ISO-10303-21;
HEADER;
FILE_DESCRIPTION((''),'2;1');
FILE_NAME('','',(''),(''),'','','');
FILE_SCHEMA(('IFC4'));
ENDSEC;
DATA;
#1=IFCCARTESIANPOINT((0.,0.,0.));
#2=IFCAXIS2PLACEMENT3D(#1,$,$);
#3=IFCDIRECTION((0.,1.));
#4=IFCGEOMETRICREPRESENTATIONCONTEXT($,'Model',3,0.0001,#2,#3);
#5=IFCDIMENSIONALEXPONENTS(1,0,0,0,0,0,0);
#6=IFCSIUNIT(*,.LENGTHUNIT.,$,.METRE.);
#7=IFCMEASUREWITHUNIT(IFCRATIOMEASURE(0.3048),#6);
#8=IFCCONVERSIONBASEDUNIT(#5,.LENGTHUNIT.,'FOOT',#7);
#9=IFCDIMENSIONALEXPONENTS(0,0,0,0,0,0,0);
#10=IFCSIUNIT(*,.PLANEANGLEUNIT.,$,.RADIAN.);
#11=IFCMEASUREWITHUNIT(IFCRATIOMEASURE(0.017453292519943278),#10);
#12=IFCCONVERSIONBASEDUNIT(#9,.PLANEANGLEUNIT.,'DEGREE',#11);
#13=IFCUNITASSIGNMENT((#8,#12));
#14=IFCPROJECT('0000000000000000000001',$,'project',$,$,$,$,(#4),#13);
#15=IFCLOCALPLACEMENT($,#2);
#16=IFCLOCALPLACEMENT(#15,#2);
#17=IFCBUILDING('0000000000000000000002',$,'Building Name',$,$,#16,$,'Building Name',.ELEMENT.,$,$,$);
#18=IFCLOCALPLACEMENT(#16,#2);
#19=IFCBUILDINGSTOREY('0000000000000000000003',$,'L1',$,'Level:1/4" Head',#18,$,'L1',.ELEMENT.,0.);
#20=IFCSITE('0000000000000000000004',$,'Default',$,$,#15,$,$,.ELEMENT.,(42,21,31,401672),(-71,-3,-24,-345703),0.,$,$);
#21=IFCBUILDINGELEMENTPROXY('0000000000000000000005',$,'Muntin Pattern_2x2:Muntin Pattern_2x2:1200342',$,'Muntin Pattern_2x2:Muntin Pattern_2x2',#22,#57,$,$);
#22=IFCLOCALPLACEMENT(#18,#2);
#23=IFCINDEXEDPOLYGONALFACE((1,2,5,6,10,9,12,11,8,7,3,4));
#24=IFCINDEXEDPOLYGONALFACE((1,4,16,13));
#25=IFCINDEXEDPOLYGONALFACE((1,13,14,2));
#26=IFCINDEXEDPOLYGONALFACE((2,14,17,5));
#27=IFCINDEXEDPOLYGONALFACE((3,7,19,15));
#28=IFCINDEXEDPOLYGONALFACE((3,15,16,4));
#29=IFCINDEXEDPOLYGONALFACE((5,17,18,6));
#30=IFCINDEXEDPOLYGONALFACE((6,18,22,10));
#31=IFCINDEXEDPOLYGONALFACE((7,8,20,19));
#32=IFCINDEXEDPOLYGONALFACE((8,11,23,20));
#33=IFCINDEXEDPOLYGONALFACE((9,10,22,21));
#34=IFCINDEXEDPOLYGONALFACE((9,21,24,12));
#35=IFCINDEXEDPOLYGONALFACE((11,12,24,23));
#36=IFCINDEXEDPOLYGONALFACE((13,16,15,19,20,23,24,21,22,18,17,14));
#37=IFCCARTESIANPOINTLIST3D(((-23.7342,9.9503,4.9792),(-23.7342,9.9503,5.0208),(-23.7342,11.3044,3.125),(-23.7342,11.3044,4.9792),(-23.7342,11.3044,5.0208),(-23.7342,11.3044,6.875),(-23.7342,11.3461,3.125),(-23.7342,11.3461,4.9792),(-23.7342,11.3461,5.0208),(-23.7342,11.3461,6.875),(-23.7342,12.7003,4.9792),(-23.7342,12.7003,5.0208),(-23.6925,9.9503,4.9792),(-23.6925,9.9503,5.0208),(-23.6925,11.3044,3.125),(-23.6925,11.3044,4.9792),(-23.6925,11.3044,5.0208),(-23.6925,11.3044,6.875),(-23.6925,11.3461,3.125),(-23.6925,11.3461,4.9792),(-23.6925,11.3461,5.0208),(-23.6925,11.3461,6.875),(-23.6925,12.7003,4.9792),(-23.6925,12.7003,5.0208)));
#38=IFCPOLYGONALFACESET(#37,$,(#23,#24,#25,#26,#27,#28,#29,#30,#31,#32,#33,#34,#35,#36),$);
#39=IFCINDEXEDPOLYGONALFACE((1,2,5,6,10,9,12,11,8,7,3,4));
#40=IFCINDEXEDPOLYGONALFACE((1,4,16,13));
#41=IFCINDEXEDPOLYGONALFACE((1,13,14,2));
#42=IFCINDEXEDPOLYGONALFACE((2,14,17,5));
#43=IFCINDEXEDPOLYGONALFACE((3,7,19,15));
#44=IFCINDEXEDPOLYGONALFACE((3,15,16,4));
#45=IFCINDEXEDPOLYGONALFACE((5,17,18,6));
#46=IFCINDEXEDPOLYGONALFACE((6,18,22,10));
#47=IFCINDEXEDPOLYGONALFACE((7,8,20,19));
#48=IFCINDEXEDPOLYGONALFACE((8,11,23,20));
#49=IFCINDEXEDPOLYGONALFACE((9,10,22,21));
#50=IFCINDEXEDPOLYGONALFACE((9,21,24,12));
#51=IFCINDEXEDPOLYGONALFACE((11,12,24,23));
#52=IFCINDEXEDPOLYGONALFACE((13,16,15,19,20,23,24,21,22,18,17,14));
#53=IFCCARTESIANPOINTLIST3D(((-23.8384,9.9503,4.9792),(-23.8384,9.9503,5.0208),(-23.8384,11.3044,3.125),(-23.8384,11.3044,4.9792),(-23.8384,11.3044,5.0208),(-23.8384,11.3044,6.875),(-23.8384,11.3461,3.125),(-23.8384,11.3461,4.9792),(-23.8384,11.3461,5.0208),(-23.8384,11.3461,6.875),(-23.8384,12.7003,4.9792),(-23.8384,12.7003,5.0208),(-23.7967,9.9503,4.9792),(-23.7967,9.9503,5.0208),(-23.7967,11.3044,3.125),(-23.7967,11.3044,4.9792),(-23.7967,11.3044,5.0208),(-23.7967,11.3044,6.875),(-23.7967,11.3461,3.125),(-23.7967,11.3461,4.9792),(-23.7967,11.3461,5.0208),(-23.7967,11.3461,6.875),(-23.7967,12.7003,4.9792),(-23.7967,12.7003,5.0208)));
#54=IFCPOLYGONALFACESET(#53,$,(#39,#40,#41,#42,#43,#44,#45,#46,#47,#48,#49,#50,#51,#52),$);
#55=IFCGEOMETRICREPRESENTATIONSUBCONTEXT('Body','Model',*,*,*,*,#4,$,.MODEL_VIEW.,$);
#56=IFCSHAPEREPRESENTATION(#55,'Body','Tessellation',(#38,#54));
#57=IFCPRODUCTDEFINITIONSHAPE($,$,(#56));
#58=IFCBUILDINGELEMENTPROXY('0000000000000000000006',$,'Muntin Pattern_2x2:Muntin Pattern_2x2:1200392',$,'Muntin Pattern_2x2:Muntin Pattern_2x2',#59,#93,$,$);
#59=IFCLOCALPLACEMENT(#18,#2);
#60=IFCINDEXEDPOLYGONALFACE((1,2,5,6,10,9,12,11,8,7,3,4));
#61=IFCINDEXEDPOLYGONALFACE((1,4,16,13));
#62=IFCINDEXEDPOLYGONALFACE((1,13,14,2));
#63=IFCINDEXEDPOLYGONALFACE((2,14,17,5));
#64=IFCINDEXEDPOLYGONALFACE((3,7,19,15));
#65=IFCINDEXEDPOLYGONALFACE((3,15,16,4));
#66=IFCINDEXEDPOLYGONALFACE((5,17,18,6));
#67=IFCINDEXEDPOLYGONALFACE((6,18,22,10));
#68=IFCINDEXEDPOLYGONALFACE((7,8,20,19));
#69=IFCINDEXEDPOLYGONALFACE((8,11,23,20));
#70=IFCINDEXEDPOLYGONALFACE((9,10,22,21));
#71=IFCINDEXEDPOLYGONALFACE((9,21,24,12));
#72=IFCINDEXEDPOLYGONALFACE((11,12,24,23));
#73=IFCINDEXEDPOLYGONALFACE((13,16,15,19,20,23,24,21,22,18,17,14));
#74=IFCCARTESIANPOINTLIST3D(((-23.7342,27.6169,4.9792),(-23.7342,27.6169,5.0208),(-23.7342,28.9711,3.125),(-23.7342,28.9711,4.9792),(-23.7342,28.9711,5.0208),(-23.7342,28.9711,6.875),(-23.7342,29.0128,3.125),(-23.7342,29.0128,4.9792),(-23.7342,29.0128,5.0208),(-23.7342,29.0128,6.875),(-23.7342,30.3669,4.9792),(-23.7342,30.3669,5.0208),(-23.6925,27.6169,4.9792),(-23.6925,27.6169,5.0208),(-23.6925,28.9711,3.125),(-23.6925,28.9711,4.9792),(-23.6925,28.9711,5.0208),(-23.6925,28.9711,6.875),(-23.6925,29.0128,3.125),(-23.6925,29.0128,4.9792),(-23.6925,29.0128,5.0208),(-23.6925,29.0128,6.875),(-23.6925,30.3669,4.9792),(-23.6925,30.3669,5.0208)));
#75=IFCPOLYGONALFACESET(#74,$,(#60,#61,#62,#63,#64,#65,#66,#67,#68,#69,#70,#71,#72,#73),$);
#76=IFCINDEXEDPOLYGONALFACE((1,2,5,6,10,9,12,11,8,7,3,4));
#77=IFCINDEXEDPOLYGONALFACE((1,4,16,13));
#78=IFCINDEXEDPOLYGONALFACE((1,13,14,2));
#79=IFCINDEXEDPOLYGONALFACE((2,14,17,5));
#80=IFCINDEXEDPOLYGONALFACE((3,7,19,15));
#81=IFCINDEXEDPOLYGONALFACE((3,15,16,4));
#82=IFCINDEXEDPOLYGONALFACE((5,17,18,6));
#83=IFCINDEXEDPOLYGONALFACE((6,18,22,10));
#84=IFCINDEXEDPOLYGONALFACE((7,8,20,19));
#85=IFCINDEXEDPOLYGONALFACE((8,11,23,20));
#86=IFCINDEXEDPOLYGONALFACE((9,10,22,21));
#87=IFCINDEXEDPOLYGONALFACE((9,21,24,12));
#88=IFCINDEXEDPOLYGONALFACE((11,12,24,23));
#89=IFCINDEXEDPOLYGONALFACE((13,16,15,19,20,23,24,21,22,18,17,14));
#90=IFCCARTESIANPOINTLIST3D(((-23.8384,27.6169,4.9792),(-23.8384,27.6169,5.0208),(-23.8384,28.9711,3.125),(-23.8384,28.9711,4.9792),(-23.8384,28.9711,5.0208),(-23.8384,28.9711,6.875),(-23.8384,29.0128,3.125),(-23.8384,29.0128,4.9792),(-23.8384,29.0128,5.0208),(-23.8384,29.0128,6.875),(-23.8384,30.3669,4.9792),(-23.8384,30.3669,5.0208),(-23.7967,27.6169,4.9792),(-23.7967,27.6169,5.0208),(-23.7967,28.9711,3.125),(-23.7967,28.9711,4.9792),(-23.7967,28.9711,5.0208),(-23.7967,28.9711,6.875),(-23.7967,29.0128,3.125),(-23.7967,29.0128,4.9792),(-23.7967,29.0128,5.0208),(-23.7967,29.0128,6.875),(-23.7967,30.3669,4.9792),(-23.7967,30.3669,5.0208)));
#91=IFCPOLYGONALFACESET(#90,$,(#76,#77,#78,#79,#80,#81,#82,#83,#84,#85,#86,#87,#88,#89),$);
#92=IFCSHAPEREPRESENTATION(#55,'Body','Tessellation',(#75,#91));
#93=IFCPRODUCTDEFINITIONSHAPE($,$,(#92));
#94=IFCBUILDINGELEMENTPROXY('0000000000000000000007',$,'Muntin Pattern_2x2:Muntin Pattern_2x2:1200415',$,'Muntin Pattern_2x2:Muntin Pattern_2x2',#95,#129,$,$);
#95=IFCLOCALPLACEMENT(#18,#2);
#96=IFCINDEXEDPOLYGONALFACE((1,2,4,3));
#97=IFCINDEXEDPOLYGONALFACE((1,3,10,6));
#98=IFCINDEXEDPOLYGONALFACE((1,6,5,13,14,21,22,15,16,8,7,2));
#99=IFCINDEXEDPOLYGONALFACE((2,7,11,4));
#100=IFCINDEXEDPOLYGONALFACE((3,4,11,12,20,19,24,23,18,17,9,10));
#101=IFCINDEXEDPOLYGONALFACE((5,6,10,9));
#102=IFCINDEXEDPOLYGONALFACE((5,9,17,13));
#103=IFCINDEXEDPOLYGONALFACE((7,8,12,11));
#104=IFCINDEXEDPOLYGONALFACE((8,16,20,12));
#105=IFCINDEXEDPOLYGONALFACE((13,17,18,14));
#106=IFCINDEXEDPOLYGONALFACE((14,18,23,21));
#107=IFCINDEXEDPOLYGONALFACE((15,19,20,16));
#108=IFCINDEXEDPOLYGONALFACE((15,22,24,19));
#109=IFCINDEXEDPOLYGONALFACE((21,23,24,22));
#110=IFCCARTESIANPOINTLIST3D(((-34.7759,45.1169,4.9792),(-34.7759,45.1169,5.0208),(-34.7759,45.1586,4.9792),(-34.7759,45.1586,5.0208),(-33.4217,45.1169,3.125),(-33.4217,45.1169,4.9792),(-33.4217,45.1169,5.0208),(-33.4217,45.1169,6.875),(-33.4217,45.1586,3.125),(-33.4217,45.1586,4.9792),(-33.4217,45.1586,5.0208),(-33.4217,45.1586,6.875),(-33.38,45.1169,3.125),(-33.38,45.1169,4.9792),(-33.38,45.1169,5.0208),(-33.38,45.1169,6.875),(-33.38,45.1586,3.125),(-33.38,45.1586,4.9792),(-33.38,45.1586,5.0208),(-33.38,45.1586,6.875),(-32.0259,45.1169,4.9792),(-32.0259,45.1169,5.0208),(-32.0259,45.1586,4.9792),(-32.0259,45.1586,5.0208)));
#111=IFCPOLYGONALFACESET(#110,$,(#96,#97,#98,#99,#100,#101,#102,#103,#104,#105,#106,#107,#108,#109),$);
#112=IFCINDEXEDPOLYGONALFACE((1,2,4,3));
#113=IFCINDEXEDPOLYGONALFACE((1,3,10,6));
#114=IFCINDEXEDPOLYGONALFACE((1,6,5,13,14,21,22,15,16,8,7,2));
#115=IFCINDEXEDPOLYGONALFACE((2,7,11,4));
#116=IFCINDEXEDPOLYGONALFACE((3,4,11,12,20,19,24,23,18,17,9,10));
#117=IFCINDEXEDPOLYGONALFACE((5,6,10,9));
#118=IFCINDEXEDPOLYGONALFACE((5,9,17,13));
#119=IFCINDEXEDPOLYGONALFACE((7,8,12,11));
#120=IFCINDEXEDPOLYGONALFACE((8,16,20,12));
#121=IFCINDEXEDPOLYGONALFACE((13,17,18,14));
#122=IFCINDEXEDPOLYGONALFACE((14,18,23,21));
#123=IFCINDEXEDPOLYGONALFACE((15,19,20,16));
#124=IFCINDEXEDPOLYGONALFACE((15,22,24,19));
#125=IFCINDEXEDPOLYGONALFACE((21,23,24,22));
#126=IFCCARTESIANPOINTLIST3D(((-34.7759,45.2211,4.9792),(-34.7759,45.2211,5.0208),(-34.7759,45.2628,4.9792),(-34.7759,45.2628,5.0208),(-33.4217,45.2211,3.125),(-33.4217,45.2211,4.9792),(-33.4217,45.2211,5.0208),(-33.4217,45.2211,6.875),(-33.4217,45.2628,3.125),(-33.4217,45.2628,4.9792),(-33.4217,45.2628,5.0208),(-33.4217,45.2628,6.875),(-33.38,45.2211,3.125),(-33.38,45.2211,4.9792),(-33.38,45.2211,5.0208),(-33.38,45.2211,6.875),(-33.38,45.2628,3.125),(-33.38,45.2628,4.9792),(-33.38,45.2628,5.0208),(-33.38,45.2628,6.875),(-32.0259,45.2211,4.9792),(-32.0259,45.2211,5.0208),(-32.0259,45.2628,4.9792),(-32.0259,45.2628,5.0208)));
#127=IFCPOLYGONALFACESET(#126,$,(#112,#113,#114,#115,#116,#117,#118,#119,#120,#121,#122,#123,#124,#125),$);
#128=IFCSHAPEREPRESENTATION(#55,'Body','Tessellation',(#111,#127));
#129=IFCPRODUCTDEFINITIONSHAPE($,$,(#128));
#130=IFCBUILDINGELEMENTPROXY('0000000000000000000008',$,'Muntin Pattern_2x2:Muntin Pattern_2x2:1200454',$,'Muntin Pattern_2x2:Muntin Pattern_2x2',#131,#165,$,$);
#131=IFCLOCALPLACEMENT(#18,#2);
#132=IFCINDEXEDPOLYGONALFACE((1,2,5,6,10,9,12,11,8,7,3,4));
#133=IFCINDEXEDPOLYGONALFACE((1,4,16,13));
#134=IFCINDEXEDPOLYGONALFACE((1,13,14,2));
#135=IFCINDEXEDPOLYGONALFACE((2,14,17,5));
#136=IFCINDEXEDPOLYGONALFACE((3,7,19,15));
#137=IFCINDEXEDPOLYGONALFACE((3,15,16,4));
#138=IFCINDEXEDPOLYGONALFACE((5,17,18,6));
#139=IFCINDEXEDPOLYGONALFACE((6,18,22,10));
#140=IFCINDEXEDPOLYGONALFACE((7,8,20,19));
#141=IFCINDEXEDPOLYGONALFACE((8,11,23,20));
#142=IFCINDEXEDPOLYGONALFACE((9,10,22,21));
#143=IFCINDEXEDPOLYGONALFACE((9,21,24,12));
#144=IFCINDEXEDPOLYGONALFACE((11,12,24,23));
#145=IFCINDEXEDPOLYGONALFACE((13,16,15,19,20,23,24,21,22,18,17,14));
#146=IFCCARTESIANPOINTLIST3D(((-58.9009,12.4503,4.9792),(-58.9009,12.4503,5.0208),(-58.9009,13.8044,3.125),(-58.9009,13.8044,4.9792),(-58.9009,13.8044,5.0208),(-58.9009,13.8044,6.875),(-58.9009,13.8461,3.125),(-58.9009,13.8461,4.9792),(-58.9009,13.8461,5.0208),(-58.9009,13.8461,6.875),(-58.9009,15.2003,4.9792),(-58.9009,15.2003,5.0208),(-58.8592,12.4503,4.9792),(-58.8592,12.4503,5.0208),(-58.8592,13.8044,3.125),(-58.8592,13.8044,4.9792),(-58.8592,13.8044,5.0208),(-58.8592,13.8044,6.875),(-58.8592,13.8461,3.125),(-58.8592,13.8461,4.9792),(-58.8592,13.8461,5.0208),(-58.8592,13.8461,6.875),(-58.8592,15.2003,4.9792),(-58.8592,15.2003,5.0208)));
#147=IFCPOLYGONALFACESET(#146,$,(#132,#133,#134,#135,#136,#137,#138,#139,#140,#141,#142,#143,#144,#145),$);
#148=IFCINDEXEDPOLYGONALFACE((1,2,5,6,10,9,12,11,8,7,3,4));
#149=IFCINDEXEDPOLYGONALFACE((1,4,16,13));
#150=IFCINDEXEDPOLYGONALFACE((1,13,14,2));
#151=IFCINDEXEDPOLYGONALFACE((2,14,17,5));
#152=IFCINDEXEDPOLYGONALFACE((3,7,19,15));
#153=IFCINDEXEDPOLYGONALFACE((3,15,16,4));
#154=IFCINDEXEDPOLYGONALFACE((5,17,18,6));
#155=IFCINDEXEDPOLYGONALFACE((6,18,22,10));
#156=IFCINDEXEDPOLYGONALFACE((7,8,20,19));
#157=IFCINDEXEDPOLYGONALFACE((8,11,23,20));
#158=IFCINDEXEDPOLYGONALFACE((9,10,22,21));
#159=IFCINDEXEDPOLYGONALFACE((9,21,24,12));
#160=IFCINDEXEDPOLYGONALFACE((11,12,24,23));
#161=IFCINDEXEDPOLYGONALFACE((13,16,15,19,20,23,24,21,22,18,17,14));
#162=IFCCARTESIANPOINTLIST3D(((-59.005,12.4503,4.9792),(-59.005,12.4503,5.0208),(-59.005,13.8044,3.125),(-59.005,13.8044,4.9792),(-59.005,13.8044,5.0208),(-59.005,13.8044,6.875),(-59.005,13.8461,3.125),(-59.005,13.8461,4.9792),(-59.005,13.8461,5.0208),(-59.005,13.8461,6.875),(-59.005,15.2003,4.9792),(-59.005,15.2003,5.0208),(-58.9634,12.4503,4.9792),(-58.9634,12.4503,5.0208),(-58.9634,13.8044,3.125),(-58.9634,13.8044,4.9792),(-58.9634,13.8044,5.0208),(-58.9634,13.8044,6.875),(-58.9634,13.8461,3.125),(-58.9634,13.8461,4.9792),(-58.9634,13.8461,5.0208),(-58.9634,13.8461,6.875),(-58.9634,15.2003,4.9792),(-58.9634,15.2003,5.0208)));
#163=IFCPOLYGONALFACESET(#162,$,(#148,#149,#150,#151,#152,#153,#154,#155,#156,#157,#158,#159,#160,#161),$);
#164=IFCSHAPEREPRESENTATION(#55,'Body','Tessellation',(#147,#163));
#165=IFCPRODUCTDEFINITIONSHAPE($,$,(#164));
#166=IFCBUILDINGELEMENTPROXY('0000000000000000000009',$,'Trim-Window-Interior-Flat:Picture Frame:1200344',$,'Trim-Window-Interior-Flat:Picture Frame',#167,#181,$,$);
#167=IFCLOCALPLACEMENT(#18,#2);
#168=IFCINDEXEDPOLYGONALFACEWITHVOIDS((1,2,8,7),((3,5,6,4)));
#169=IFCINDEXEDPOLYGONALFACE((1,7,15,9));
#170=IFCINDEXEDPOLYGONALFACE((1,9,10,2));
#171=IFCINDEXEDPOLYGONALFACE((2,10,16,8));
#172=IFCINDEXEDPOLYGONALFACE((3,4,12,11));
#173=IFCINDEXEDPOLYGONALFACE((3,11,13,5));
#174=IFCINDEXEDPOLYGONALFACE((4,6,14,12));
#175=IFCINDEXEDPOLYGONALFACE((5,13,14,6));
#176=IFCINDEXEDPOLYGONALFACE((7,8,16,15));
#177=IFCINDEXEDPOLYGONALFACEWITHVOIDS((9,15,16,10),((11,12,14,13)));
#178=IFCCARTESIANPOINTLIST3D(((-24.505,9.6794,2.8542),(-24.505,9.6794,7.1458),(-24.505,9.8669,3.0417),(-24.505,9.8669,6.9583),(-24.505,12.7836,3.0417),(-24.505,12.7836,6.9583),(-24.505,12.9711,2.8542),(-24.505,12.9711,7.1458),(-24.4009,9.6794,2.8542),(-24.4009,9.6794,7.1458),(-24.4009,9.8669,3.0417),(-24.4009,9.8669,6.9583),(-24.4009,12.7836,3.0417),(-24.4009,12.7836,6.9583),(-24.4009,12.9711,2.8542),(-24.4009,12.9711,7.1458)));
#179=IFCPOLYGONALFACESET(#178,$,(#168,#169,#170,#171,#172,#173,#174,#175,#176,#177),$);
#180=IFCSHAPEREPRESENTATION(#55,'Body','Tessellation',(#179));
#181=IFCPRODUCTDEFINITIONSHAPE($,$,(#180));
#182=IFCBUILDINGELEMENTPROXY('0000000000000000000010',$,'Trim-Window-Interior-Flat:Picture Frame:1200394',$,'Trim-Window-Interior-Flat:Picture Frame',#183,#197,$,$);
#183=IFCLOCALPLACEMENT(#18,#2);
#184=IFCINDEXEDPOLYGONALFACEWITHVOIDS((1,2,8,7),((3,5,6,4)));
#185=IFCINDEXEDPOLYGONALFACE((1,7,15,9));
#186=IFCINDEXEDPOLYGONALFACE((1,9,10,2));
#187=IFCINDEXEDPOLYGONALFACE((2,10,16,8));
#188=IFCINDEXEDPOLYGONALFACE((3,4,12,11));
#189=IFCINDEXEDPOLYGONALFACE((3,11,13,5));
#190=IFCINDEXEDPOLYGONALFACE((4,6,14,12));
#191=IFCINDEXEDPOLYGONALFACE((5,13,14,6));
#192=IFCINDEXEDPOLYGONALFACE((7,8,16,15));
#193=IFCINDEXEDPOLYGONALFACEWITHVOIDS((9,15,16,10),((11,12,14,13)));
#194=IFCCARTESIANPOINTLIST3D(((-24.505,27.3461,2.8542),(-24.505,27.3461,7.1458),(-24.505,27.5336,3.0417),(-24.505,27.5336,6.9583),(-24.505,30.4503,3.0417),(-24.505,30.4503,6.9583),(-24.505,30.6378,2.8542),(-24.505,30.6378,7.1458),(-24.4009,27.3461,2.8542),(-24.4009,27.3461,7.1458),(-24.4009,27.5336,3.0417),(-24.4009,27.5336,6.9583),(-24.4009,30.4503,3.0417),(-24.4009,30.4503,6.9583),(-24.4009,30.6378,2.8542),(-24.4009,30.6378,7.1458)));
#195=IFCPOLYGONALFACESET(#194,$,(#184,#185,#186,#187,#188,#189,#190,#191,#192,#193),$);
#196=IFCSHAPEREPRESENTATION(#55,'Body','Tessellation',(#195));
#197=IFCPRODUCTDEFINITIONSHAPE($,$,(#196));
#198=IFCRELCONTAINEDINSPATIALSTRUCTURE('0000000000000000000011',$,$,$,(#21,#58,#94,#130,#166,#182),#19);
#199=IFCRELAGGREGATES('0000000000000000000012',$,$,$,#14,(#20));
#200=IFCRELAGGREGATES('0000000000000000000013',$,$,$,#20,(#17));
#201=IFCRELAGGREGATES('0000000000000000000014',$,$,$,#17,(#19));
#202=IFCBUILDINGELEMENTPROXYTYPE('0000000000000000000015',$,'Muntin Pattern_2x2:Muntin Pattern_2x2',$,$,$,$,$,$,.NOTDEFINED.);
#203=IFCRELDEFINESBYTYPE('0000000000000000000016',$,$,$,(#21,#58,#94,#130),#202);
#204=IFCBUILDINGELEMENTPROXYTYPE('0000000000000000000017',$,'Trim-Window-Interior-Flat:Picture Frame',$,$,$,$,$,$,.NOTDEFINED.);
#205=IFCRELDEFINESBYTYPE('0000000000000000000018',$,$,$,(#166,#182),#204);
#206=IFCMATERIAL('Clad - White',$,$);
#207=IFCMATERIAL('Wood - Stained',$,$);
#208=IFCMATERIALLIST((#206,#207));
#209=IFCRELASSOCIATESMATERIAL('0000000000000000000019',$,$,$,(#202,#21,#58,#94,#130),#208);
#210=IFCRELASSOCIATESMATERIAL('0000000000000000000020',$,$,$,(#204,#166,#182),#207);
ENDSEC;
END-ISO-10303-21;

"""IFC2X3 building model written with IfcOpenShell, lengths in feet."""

from ifc_helpers import new_model, entity, si_unit, converted_unit, direction, frame, origin, place, context, subcontext, project, spatial, polyline, outline, extrude, source, transform, mapped, material, material_list, type_object, type_shapes, element, save


model = new_model("IFC2X3")

# Units and contexts
model_context = context("Model", 3, precision=0.0001, world=origin(), true_north=direction((0.0, 1.0)))
body_context = subcontext(model_context, "Body", "Model", "MODEL_VIEW")
ifc_project = project(units=[converted_unit("LENGTHUNIT", "FOOT", entity("IfcRatioMeasure", 0.3048), si_unit("LENGTHUNIT", "METRE"), dimensions=[1, 0, 0, 0, 0, 0, 0]), converted_unit("PLANEANGLEUNIT", "DEGREE", entity("IfcRatioMeasure", 0.017453292519943278), si_unit("PLANEANGLEUNIT", "RADIAN"), dimensions=[0, 0, 0, 0, 0, 0, 0])], contexts=[model_context])

# Site, building, storey
site_placement = place(None, origin())
site = spatial("IfcSite", under=ifc_project, at=site_placement, Name="Default", CompositionType="ELEMENT", RefLatitude=(42, 21, 31, 401672), RefLongitude=(-71, -3, -24, -345703), RefElevation=0.0)
building_placement = place(site_placement, origin())
building = spatial("IfcBuilding", under=site, at=building_placement, Name="Building Name", LongName="Building Name", CompositionType="ELEMENT")
storey_placement = place(building_placement, origin())
storey = spatial("IfcBuildingStorey", under=building, at=storey_placement, Name="L1", ObjectType="Level:1/4\" Head", LongName="L1", CompositionType="ELEMENT", Elevation=0.0)

# Building element proxies
ifc_material_1 = material(Name="Clad - White")
ifc_material_2 = material(Name="Wood - Stained")
ifc_material_list = material_list([ifc_material_1, ifc_material_2])
building_element_proxy_type_1 = type_object("IfcBuildingElementProxyType", Name="Muntin Pattern_2x2:Muntin Pattern_2x2", PredefinedType="NOTDEFINED", material=ifc_material_list)
shared_shape_1 = source(origin(), body_context, "Body", "SweptSolid", [
    extrude(outline(polyline([(0.0208, -0.0208), (1.875, -0.0208), (1.875, 0.0208), (0.0208, 0.0208), (0.0208, 1.375), (-0.0208, 1.375), (-0.0208, 0.0208), (-1.875, 0.0208), (-1.875, -0.0208), (-0.0208, -0.0208), (-0.0208, -1.375), (0.0208, -1.375), (0.0208, -0.0208)])), frame((0.0, -0.0729, 1.875), z_axis=(0.0, 1.0, 0.0), x_axis=(0.0, 0.0, 1.0)), (0.0, 0.0, 1.0), 0.0417),
    extrude(outline(polyline([(0.0208, -0.0208), (1.875, -0.0208), (1.875, 0.0208), (0.0208, 0.0208), (0.0208, 1.375), (-0.0208, 1.375), (-0.0208, 0.0208), (-1.875, 0.0208), (-1.875, -0.0208), (-0.0208, -0.0208), (-0.0208, -1.375), (0.0208, -1.375), (0.0208, -0.0208)])), frame((0.0, 0.0313, 1.875), z_axis=(0.0, 1.0, 0.0), x_axis=(0.0, 0.0, 1.0)), (0.0, 0.0, 1.0), 0.0417),
])
type_shapes(building_element_proxy_type_1, [shared_shape_1])
for number, where, z_axis, x_axis, name in (
    (1, (-23.7654, 11.3253, 3.125), (0.0, 0.0, 1.0), (0.0, 1.0, 0.0), "Muntin Pattern_2x2:Muntin Pattern_2x2:1200342"),
    (2, (-23.7654, 28.9919, 3.125), (0.0, 0.0, 1.0), (0.0, 1.0, 0.0), "Muntin Pattern_2x2:Muntin Pattern_2x2:1200392"),
):
    element("IfcBuildingElementProxy", number, at=place(storey_placement, frame(where, z_axis=z_axis, x_axis=x_axis)), inside=storey, type_object=building_element_proxy_type_1, material=ifc_material_list, Name=name, ObjectType="Muntin Pattern_2x2:Muntin Pattern_2x2", context=body_context, shape_type="MappedRepresentation", body=[
        mapped(shared_shape_1, transform((0.0, 0.0, 0.0), scale=1.0)),
    ])
proxy_1_placement = place(storey_placement, frame((-33.4009, 45.1898, 3.125)))
element("IfcBuildingElementProxy", 3, at=proxy_1_placement, inside=storey, type_object=building_element_proxy_type_1, material=ifc_material_list, Name="Muntin Pattern_2x2:Muntin Pattern_2x2:1200415", ObjectType="Muntin Pattern_2x2:Muntin Pattern_2x2", context=body_context, shape_type="MappedRepresentation", body=[
    mapped(shared_shape_1, transform((0.0, 0.0, 0.0), scale=1.0)),
])
proxy_2_placement = place(storey_placement, frame((-58.9321, 13.8253, 3.125), z_axis=(0.0, 0.0, 1.0), x_axis=(0.0, 1.0, 0.0)))
element("IfcBuildingElementProxy", 4, at=proxy_2_placement, inside=storey, type_object=building_element_proxy_type_1, material=ifc_material_list, Name="Muntin Pattern_2x2:Muntin Pattern_2x2:1200454", ObjectType="Muntin Pattern_2x2:Muntin Pattern_2x2", context=body_context, shape_type="MappedRepresentation", body=[
    mapped(shared_shape_1, transform((0.0, 0.0, 0.0), scale=1.0)),
])
building_element_proxy_type_2 = type_object("IfcBuildingElementProxyType", Name="Trim-Window-Interior-Flat:Picture Frame", PredefinedType="NOTDEFINED", material=ifc_material_2)
shared_shape_2 = source(origin(), body_context, "Body", "SweptSolid", [
    extrude(outline(polyline([(-1.6458, -2.1458), (1.6458, -2.1458), (1.6458, 2.1458), (-1.6458, 2.1458), (-1.6458, -2.1458)]), holes=[polyline([(-1.4583, -1.9583), (-1.4583, 1.9583), (1.4583, 1.9583), (1.4583, -1.9583), (-1.4583, -1.9583)])]), frame((0.0, -2.0, 0.0), z_axis=(0.0, 0.0, 1.0), x_axis=(-1.0, 0.0, 0.0)), (0.0, 0.0, 1.0), 0.1042),
])
type_shapes(building_element_proxy_type_2, [shared_shape_2])
for number, where, z_axis, x_axis, name in (
    (5, (-24.4009, 11.3253, 7.0), (-1.0, 0.0, 0.0), (0.0, -1.0, 0.0), "Trim-Window-Interior-Flat:Picture Frame:1200344"),
    (6, (-24.4009, 28.9919, 7.0), (-1.0, 0.0, 0.0), (0.0, -1.0, 0.0), "Trim-Window-Interior-Flat:Picture Frame:1200394"),
):
    element("IfcBuildingElementProxy", number, at=place(storey_placement, frame(where, z_axis=z_axis, x_axis=x_axis)), inside=storey, type_object=building_element_proxy_type_2, material=ifc_material_2, Name=name, ObjectType="Trim-Window-Interior-Flat:Picture Frame", context=body_context, shape_type="MappedRepresentation", body=[
        mapped(shared_shape_2, transform((0.0, 0.0, 0.0), scale=1.0)),
    ])

save(model, "model.ifc")
